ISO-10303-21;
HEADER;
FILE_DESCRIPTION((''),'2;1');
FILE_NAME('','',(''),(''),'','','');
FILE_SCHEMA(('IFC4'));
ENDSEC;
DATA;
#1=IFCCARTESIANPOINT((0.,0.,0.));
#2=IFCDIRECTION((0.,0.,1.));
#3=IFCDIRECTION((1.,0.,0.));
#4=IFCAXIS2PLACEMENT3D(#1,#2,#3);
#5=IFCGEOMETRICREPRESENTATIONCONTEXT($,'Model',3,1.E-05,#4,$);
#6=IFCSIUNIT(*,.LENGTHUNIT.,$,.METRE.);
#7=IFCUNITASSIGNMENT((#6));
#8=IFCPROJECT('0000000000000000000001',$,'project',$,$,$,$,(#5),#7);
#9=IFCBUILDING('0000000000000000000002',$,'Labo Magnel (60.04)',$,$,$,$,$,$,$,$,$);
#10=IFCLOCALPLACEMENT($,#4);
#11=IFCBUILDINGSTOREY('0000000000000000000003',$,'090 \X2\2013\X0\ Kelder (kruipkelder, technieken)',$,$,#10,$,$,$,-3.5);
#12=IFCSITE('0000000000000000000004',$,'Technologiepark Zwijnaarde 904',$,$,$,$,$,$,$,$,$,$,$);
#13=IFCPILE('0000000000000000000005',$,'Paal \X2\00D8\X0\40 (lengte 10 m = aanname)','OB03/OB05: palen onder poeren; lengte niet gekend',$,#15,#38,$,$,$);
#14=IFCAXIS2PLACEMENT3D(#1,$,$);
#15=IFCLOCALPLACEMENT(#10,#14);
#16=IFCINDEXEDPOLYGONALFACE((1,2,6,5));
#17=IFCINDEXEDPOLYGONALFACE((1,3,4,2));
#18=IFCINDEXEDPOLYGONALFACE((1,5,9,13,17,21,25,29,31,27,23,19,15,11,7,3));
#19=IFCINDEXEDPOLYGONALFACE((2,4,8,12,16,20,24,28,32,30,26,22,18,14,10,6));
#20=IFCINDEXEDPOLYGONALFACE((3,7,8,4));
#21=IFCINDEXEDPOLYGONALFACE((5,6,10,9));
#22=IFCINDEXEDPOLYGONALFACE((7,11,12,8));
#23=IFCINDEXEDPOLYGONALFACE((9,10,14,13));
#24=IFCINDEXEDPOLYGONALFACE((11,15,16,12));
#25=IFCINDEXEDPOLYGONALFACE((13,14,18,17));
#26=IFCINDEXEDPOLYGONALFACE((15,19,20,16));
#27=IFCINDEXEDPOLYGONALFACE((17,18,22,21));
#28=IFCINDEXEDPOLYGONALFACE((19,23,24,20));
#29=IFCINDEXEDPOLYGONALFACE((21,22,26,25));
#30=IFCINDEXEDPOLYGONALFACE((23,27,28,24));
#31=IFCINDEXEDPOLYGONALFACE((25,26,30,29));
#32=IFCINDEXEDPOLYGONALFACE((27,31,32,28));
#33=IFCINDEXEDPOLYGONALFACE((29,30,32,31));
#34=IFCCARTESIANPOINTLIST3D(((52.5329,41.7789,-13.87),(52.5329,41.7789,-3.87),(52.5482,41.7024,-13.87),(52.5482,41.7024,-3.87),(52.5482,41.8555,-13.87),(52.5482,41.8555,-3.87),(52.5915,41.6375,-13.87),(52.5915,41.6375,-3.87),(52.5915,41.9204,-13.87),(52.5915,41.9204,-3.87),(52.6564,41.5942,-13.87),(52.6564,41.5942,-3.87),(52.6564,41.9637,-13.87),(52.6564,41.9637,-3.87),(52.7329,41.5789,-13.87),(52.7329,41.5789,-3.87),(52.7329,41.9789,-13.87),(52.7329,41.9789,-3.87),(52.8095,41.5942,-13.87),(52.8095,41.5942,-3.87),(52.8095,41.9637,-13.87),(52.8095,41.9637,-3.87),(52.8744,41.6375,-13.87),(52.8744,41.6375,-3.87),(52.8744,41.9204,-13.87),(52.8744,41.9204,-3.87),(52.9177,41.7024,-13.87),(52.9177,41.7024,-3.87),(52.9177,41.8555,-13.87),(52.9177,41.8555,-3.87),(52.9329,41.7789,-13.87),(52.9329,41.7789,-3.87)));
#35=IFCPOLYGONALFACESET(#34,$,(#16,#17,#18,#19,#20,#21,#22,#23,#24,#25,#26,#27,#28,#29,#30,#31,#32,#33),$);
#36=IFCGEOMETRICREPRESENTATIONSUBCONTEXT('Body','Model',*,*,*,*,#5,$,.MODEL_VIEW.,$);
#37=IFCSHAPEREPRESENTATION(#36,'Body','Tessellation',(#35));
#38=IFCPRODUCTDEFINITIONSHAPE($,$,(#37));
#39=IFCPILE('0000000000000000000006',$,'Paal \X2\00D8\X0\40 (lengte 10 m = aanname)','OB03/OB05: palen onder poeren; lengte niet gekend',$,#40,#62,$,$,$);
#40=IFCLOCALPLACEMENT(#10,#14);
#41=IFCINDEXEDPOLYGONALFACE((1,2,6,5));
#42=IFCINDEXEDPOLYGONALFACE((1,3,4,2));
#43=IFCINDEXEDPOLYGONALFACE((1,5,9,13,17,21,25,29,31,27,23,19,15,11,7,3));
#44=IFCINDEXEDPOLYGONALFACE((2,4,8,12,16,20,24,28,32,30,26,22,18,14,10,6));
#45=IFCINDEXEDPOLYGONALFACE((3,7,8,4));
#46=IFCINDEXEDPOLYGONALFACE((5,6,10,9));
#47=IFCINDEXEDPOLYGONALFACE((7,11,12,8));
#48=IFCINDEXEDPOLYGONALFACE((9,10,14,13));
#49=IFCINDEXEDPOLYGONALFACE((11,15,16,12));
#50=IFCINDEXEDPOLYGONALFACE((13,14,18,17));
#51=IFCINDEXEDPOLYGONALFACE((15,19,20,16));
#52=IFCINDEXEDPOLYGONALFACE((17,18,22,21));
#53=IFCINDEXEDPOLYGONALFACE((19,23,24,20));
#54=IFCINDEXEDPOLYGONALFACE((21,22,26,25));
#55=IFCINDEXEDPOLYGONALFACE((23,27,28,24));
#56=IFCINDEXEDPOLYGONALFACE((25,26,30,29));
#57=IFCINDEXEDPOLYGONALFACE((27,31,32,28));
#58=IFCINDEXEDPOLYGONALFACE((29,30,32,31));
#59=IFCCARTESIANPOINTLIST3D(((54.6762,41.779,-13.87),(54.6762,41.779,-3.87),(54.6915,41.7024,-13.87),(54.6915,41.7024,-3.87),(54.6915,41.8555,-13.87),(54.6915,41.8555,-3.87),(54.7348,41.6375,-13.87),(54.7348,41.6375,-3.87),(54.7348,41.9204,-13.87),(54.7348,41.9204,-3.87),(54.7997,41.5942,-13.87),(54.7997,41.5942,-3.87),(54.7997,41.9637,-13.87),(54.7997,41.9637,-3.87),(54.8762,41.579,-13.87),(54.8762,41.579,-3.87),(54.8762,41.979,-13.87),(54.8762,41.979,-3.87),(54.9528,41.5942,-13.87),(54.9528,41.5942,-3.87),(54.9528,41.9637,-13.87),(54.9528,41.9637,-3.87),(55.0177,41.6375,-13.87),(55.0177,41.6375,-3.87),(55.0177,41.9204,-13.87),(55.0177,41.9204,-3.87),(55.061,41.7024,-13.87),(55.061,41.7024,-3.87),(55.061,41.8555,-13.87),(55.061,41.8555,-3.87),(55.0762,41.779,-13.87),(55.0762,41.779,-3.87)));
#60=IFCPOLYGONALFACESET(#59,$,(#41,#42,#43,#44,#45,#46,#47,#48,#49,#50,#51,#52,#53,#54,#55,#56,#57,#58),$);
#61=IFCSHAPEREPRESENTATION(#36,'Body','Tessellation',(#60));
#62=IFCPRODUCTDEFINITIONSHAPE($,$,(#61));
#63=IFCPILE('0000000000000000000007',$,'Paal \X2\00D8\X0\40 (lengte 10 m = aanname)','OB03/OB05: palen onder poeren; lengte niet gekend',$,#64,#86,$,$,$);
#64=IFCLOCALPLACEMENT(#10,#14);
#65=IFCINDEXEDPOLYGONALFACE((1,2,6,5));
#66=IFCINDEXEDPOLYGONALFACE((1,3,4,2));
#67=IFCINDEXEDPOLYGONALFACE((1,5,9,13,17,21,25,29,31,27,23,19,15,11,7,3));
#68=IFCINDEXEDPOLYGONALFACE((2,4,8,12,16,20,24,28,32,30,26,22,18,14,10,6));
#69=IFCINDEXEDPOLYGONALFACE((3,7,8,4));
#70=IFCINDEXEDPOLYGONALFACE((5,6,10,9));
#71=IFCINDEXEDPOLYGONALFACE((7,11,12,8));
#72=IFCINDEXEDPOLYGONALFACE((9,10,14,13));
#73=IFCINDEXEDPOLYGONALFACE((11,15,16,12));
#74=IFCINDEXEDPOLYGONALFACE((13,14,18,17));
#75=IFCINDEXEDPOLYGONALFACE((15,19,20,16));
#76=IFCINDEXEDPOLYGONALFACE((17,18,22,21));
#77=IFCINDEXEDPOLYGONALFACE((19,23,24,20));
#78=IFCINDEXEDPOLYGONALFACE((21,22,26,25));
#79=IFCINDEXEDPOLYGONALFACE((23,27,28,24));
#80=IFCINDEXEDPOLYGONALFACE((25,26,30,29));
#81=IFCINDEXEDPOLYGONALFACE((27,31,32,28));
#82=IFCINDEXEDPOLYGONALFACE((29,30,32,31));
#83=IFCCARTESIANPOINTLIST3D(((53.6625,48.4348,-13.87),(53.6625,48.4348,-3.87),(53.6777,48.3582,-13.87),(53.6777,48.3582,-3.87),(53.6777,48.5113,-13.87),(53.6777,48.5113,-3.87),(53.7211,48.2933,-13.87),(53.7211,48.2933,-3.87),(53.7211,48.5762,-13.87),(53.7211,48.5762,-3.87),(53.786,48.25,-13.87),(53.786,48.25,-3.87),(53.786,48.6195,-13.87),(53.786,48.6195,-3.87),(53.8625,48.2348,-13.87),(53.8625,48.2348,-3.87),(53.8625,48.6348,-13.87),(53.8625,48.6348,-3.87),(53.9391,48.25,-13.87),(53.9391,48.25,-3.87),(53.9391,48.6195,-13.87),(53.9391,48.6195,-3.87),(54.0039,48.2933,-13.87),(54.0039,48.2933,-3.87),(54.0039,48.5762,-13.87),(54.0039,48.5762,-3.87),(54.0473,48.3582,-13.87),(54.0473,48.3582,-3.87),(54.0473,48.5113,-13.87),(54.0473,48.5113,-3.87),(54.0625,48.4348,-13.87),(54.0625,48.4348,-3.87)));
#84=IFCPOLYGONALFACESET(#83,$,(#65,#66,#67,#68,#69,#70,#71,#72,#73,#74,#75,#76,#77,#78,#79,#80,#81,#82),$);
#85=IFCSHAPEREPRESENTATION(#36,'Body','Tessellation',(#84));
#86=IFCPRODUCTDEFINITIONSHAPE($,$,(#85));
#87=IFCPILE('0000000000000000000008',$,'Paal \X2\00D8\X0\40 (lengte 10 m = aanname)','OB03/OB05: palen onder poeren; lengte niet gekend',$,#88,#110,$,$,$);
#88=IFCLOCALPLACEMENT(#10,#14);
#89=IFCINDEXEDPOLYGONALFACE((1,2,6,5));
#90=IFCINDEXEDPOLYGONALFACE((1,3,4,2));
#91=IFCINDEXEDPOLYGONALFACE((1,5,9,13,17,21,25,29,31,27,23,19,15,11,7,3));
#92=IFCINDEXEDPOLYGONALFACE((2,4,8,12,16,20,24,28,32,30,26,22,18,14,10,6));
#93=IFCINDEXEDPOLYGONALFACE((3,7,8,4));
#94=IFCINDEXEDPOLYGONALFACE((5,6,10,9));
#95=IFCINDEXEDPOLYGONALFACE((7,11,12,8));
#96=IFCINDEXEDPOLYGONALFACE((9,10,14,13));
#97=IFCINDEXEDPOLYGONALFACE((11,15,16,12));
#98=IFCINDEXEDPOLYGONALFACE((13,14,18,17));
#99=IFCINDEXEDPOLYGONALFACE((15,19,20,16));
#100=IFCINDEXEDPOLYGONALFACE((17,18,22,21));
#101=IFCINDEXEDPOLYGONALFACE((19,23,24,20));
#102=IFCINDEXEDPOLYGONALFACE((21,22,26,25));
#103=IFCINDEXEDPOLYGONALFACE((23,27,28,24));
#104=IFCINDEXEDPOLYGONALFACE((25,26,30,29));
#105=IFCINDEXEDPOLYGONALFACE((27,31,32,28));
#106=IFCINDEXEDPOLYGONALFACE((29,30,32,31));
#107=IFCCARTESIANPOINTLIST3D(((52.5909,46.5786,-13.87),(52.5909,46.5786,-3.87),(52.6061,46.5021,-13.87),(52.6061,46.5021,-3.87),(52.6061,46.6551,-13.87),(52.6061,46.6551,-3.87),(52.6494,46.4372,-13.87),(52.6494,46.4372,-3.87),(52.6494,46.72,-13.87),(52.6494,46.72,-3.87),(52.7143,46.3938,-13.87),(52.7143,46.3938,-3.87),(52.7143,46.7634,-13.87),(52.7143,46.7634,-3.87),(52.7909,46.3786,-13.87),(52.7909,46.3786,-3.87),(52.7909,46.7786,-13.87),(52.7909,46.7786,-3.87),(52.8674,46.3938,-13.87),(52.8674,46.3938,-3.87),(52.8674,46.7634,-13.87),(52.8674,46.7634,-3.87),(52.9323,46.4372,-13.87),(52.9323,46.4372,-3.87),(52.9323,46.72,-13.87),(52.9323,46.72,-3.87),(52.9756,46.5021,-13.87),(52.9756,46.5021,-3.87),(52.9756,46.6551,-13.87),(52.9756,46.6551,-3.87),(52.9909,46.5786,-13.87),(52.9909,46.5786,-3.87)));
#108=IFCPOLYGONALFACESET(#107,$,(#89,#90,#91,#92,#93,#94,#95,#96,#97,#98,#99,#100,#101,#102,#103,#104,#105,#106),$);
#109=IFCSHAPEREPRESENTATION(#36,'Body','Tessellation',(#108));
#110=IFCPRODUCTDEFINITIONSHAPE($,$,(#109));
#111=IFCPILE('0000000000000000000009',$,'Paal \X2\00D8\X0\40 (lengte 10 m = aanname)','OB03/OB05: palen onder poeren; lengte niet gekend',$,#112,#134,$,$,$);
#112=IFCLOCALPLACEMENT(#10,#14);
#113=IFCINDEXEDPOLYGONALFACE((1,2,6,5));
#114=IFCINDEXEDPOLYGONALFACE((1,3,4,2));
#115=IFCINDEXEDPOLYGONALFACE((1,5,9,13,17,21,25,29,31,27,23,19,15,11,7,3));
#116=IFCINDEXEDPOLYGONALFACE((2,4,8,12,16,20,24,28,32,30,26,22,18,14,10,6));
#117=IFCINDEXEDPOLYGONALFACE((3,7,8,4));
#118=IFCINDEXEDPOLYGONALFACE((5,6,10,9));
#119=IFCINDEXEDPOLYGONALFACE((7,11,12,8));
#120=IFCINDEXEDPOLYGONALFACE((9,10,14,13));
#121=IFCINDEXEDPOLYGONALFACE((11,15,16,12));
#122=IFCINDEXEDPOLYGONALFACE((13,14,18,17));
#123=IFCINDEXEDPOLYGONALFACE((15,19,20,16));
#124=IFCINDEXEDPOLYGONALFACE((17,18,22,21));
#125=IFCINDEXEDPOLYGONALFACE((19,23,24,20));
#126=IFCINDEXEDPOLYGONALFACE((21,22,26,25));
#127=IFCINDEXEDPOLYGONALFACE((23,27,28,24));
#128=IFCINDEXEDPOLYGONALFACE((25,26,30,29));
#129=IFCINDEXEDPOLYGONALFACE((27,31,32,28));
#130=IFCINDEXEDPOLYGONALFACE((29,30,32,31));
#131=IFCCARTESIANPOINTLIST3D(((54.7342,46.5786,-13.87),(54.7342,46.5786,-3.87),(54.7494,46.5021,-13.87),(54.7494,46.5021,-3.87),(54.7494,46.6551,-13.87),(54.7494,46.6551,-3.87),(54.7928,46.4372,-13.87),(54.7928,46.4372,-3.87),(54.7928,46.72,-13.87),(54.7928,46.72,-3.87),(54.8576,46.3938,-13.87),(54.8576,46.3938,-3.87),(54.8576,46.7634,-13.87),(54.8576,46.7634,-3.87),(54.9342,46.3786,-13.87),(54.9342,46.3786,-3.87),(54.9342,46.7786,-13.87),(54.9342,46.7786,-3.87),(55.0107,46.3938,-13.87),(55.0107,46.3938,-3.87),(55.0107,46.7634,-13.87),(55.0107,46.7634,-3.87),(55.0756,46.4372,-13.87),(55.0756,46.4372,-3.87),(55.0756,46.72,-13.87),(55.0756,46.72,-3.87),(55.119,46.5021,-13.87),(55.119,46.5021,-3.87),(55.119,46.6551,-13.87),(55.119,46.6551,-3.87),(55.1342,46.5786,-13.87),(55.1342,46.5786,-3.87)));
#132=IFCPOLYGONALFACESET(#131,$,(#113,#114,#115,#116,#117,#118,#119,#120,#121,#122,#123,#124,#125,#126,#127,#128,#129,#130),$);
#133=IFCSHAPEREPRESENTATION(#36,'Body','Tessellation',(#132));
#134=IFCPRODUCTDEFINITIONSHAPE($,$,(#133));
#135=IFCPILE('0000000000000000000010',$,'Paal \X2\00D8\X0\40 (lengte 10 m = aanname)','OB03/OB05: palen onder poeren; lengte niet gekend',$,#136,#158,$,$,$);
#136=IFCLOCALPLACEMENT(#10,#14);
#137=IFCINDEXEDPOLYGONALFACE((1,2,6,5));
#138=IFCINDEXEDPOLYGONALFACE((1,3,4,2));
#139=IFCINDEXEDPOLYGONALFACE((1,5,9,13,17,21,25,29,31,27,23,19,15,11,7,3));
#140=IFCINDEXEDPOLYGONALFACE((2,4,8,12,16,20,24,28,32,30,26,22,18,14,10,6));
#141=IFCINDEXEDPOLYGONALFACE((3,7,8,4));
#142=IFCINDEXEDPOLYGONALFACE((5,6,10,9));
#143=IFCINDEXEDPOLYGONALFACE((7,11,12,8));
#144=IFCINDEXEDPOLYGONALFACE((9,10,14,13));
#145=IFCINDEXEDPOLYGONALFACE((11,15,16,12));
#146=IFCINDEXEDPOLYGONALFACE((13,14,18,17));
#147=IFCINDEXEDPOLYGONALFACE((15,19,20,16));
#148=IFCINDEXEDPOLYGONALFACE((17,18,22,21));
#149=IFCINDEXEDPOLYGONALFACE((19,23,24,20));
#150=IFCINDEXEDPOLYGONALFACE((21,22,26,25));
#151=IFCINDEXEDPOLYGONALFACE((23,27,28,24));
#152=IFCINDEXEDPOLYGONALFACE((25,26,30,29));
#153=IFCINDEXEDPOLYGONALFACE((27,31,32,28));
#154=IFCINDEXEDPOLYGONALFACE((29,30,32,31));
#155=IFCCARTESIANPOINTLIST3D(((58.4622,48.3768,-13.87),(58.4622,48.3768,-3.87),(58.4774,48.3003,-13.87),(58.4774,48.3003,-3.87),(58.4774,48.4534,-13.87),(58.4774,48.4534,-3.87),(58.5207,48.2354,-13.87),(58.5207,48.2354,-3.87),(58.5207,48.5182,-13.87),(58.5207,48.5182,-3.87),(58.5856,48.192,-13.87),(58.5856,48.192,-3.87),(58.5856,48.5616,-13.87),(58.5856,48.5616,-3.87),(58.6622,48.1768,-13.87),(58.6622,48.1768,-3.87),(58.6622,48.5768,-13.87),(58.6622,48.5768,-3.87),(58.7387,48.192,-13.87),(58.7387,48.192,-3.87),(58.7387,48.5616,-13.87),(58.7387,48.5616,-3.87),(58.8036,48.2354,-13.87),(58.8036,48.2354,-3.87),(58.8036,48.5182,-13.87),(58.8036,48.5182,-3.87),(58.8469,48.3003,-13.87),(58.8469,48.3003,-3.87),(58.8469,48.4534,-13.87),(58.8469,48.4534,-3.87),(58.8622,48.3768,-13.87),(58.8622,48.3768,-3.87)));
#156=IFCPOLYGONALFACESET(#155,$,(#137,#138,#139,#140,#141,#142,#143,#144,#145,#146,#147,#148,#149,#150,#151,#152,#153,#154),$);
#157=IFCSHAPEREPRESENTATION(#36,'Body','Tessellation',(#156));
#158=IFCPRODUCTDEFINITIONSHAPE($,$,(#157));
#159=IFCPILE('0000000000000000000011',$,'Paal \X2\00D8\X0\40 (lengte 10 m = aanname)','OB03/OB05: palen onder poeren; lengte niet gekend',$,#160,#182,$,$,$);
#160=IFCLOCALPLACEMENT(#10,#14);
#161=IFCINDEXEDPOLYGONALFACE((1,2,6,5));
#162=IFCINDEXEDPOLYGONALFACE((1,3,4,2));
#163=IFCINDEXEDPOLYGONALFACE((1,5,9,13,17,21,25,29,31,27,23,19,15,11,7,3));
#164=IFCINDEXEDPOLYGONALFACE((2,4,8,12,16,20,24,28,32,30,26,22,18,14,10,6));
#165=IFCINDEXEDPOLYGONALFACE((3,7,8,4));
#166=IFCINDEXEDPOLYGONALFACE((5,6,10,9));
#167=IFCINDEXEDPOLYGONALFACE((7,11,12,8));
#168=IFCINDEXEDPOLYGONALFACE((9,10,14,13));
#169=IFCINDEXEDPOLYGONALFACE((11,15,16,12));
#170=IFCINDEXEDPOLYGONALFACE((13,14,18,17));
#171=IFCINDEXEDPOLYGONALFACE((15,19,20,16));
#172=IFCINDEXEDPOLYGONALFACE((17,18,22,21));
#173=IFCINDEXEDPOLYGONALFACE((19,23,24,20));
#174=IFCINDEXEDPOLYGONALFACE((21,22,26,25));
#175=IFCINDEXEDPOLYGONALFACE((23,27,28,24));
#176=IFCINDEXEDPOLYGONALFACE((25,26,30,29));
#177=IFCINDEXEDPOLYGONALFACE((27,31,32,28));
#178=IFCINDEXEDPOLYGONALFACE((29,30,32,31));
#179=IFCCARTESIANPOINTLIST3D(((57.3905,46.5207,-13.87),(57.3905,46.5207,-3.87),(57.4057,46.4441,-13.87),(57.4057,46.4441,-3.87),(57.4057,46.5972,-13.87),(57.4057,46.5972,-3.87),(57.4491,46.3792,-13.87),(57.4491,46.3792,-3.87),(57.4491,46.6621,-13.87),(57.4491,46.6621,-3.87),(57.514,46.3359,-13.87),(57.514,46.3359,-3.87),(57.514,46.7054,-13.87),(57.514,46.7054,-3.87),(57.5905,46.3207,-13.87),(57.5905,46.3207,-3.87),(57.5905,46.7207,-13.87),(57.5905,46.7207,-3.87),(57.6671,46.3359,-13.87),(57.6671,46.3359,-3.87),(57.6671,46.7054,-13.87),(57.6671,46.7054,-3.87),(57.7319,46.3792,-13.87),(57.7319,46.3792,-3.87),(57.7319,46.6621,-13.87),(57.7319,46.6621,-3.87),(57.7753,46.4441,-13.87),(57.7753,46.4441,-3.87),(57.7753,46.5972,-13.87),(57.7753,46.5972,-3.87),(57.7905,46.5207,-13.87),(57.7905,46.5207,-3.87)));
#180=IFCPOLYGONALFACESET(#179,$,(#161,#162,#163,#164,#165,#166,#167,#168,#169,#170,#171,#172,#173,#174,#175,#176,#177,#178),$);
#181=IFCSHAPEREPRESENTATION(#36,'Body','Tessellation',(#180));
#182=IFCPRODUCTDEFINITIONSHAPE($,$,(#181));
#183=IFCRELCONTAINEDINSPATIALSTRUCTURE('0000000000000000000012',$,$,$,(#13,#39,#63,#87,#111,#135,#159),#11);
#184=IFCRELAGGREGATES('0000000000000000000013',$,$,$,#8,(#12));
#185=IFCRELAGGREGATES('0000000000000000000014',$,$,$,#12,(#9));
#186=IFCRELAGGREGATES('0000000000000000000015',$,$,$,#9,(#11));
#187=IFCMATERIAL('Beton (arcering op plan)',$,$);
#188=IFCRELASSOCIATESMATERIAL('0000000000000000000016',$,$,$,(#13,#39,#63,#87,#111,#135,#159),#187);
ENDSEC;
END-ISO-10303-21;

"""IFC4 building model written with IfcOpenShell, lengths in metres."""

from ifc_helpers import new_model, si_unit, frame, origin, origin_with_axes, place, context, subcontext, project, spatial, polyline, outline, extrude, material, element, save


model = new_model("IFC4")

# Units and contexts
model_context = context("Model", 3, precision=1e-05, world=origin_with_axes())
body_context = subcontext(model_context, "Body", "Model", "MODEL_VIEW")
ifc_project = project(units=[si_unit("LENGTHUNIT", "METRE")], contexts=[model_context])

# Site, building, storey
site = spatial("IfcSite", under=ifc_project, Name="Technologiepark Zwijnaarde 904")
building = spatial("IfcBuilding", under=site, Name="Labo Magnel (60.04)")
storey_placement = place(None, origin_with_axes())
storey = spatial("IfcBuildingStorey", under=building, at=storey_placement, Name="090 – Kelder (kruipkelder, technieken)", Elevation=-3.5)

# Piles
ifc_material = material(Name="Beton (arcering op plan)")
pile_1_placement = place(storey_placement, frame((0.0, 0.0, -13.87), z_axis=(0.0, 0.0, 1.0), x_axis=(1.0, 0.0, 0.0)))
element("IfcPile", 1, at=pile_1_placement, inside=storey, material=ifc_material, Name="Paal Ø40 (lengte 10 m = aanname)", Description="OB03/OB05: palen onder poeren; lengte niet gekend", context=body_context, shape_type="SweptSolid", body=[
    extrude(outline(polyline([(52.9329, 41.7789), (52.9177, 41.7024), (52.8744, 41.6375), (52.8095, 41.5942), (52.7329, 41.5789), (52.6564, 41.5942), (52.5915, 41.6375), (52.5482, 41.7024), (52.5329, 41.7789), (52.5482, 41.8555), (52.5915, 41.9204), (52.6564, 41.9637), (52.7329, 41.9789), (52.8095, 41.9637), (52.8744, 41.9204), (52.9177, 41.8555), (52.9329, 41.7789)])), origin(), (0.0, 0.0, 1.0), 10.0),
])
pile_2_placement = place(storey_placement, frame((0.0, 0.0, -13.87), z_axis=(0.0, 0.0, 1.0), x_axis=(1.0, 0.0, 0.0)))
element("IfcPile", 2, at=pile_2_placement, inside=storey, material=ifc_material, Name="Paal Ø40 (lengte 10 m = aanname)", Description="OB03/OB05: palen onder poeren; lengte niet gekend", context=body_context, shape_type="SweptSolid", body=[
    extrude(outline(polyline([(55.0762, 41.779), (55.061, 41.7024), (55.0177, 41.6375), (54.9528, 41.5942), (54.8762, 41.579), (54.7997, 41.5942), (54.7348, 41.6375), (54.6915, 41.7024), (54.6762, 41.779), (54.6915, 41.8555), (54.7348, 41.9204), (54.7997, 41.9637), (54.8762, 41.979), (54.9528, 41.9637), (55.0177, 41.9204), (55.061, 41.8555), (55.0762, 41.779)])), origin(), (0.0, 0.0, 1.0), 10.0),
])
pile_3_placement = place(storey_placement, frame((0.0, 0.0, -13.87), z_axis=(0.0, 0.0, 1.0), x_axis=(1.0, 0.0, 0.0)))
element("IfcPile", 3, at=pile_3_placement, inside=storey, material=ifc_material, Name="Paal Ø40 (lengte 10 m = aanname)", Description="OB03/OB05: palen onder poeren; lengte niet gekend", context=body_context, shape_type="SweptSolid", body=[
    extrude(outline(polyline([(54.0625, 48.4348), (54.0473, 48.3582), (54.0039, 48.2933), (53.9391, 48.25), (53.8625, 48.2348), (53.786, 48.25), (53.7211, 48.2933), (53.6777, 48.3582), (53.6625, 48.4348), (53.6777, 48.5113), (53.7211, 48.5762), (53.786, 48.6195), (53.8625, 48.6348), (53.9391, 48.6195), (54.0039, 48.5762), (54.0473, 48.5113), (54.0625, 48.4348)])), origin(), (0.0, 0.0, 1.0), 10.0),
])
pile_4_placement = place(storey_placement, frame((0.0, 0.0, -13.87), z_axis=(0.0, 0.0, 1.0), x_axis=(1.0, 0.0, 0.0)))
element("IfcPile", 4, at=pile_4_placement, inside=storey, material=ifc_material, Name="Paal Ø40 (lengte 10 m = aanname)", Description="OB03/OB05: palen onder poeren; lengte niet gekend", context=body_context, shape_type="SweptSolid", body=[
    extrude(outline(polyline([(52.9909, 46.5786), (52.9756, 46.5021), (52.9323, 46.4372), (52.8674, 46.3938), (52.7909, 46.3786), (52.7143, 46.3938), (52.6494, 46.4372), (52.6061, 46.5021), (52.5909, 46.5786), (52.6061, 46.6551), (52.6494, 46.72), (52.7143, 46.7634), (52.7909, 46.7786), (52.8674, 46.7634), (52.9323, 46.72), (52.9756, 46.6551), (52.9909, 46.5786)])), origin(), (0.0, 0.0, 1.0), 10.0),
])
pile_5_placement = place(storey_placement, frame((0.0, 0.0, -13.87), z_axis=(0.0, 0.0, 1.0), x_axis=(1.0, 0.0, 0.0)))
element("IfcPile", 5, at=pile_5_placement, inside=storey, material=ifc_material, Name="Paal Ø40 (lengte 10 m = aanname)", Description="OB03/OB05: palen onder poeren; lengte niet gekend", context=body_context, shape_type="SweptSolid", body=[
    extrude(outline(polyline([(55.1342, 46.5786), (55.119, 46.5021), (55.0756, 46.4372), (55.0107, 46.3938), (54.9342, 46.3786), (54.8576, 46.3938), (54.7928, 46.4372), (54.7494, 46.5021), (54.7342, 46.5786), (54.7494, 46.6551), (54.7928, 46.72), (54.8576, 46.7634), (54.9342, 46.7786), (55.0107, 46.7634), (55.0756, 46.72), (55.119, 46.6551), (55.1342, 46.5786)])), origin(), (0.0, 0.0, 1.0), 10.0),
])
pile_6_placement = place(storey_placement, frame((0.0, 0.0, -13.87), z_axis=(0.0, 0.0, 1.0), x_axis=(1.0, 0.0, 0.0)))
element("IfcPile", 6, at=pile_6_placement, inside=storey, material=ifc_material, Name="Paal Ø40 (lengte 10 m = aanname)", Description="OB03/OB05: palen onder poeren; lengte niet gekend", context=body_context, shape_type="SweptSolid", body=[
    extrude(outline(polyline([(58.8622, 48.3768), (58.8469, 48.3003), (58.8036, 48.2354), (58.7387, 48.192), (58.6622, 48.1768), (58.5856, 48.192), (58.5207, 48.2354), (58.4774, 48.3003), (58.4622, 48.3768), (58.4774, 48.4534), (58.5207, 48.5182), (58.5856, 48.5616), (58.6622, 48.5768), (58.7387, 48.5616), (58.8036, 48.5182), (58.8469, 48.4534), (58.8622, 48.3768)])), origin(), (0.0, 0.0, 1.0), 10.0),
])
pile_7_placement = place(storey_placement, frame((0.0, 0.0, -13.87), z_axis=(0.0, 0.0, 1.0), x_axis=(1.0, 0.0, 0.0)))
element("IfcPile", 7, at=pile_7_placement, inside=storey, material=ifc_material, Name="Paal Ø40 (lengte 10 m = aanname)", Description="OB03/OB05: palen onder poeren; lengte niet gekend", context=body_context, shape_type="SweptSolid", body=[
    extrude(outline(polyline([(57.7905, 46.5207), (57.7753, 46.4441), (57.7319, 46.3792), (57.6671, 46.3359), (57.5905, 46.3207), (57.514, 46.3359), (57.4491, 46.3792), (57.4057, 46.4441), (57.3905, 46.5207), (57.4057, 46.5972), (57.4491, 46.6621), (57.514, 46.7054), (57.5905, 46.7207), (57.6671, 46.7054), (57.7319, 46.6621), (57.7753, 46.5972), (57.7905, 46.5207)])), origin(), (0.0, 0.0, 1.0), 10.0),
])

save(model, "model.ifc")
